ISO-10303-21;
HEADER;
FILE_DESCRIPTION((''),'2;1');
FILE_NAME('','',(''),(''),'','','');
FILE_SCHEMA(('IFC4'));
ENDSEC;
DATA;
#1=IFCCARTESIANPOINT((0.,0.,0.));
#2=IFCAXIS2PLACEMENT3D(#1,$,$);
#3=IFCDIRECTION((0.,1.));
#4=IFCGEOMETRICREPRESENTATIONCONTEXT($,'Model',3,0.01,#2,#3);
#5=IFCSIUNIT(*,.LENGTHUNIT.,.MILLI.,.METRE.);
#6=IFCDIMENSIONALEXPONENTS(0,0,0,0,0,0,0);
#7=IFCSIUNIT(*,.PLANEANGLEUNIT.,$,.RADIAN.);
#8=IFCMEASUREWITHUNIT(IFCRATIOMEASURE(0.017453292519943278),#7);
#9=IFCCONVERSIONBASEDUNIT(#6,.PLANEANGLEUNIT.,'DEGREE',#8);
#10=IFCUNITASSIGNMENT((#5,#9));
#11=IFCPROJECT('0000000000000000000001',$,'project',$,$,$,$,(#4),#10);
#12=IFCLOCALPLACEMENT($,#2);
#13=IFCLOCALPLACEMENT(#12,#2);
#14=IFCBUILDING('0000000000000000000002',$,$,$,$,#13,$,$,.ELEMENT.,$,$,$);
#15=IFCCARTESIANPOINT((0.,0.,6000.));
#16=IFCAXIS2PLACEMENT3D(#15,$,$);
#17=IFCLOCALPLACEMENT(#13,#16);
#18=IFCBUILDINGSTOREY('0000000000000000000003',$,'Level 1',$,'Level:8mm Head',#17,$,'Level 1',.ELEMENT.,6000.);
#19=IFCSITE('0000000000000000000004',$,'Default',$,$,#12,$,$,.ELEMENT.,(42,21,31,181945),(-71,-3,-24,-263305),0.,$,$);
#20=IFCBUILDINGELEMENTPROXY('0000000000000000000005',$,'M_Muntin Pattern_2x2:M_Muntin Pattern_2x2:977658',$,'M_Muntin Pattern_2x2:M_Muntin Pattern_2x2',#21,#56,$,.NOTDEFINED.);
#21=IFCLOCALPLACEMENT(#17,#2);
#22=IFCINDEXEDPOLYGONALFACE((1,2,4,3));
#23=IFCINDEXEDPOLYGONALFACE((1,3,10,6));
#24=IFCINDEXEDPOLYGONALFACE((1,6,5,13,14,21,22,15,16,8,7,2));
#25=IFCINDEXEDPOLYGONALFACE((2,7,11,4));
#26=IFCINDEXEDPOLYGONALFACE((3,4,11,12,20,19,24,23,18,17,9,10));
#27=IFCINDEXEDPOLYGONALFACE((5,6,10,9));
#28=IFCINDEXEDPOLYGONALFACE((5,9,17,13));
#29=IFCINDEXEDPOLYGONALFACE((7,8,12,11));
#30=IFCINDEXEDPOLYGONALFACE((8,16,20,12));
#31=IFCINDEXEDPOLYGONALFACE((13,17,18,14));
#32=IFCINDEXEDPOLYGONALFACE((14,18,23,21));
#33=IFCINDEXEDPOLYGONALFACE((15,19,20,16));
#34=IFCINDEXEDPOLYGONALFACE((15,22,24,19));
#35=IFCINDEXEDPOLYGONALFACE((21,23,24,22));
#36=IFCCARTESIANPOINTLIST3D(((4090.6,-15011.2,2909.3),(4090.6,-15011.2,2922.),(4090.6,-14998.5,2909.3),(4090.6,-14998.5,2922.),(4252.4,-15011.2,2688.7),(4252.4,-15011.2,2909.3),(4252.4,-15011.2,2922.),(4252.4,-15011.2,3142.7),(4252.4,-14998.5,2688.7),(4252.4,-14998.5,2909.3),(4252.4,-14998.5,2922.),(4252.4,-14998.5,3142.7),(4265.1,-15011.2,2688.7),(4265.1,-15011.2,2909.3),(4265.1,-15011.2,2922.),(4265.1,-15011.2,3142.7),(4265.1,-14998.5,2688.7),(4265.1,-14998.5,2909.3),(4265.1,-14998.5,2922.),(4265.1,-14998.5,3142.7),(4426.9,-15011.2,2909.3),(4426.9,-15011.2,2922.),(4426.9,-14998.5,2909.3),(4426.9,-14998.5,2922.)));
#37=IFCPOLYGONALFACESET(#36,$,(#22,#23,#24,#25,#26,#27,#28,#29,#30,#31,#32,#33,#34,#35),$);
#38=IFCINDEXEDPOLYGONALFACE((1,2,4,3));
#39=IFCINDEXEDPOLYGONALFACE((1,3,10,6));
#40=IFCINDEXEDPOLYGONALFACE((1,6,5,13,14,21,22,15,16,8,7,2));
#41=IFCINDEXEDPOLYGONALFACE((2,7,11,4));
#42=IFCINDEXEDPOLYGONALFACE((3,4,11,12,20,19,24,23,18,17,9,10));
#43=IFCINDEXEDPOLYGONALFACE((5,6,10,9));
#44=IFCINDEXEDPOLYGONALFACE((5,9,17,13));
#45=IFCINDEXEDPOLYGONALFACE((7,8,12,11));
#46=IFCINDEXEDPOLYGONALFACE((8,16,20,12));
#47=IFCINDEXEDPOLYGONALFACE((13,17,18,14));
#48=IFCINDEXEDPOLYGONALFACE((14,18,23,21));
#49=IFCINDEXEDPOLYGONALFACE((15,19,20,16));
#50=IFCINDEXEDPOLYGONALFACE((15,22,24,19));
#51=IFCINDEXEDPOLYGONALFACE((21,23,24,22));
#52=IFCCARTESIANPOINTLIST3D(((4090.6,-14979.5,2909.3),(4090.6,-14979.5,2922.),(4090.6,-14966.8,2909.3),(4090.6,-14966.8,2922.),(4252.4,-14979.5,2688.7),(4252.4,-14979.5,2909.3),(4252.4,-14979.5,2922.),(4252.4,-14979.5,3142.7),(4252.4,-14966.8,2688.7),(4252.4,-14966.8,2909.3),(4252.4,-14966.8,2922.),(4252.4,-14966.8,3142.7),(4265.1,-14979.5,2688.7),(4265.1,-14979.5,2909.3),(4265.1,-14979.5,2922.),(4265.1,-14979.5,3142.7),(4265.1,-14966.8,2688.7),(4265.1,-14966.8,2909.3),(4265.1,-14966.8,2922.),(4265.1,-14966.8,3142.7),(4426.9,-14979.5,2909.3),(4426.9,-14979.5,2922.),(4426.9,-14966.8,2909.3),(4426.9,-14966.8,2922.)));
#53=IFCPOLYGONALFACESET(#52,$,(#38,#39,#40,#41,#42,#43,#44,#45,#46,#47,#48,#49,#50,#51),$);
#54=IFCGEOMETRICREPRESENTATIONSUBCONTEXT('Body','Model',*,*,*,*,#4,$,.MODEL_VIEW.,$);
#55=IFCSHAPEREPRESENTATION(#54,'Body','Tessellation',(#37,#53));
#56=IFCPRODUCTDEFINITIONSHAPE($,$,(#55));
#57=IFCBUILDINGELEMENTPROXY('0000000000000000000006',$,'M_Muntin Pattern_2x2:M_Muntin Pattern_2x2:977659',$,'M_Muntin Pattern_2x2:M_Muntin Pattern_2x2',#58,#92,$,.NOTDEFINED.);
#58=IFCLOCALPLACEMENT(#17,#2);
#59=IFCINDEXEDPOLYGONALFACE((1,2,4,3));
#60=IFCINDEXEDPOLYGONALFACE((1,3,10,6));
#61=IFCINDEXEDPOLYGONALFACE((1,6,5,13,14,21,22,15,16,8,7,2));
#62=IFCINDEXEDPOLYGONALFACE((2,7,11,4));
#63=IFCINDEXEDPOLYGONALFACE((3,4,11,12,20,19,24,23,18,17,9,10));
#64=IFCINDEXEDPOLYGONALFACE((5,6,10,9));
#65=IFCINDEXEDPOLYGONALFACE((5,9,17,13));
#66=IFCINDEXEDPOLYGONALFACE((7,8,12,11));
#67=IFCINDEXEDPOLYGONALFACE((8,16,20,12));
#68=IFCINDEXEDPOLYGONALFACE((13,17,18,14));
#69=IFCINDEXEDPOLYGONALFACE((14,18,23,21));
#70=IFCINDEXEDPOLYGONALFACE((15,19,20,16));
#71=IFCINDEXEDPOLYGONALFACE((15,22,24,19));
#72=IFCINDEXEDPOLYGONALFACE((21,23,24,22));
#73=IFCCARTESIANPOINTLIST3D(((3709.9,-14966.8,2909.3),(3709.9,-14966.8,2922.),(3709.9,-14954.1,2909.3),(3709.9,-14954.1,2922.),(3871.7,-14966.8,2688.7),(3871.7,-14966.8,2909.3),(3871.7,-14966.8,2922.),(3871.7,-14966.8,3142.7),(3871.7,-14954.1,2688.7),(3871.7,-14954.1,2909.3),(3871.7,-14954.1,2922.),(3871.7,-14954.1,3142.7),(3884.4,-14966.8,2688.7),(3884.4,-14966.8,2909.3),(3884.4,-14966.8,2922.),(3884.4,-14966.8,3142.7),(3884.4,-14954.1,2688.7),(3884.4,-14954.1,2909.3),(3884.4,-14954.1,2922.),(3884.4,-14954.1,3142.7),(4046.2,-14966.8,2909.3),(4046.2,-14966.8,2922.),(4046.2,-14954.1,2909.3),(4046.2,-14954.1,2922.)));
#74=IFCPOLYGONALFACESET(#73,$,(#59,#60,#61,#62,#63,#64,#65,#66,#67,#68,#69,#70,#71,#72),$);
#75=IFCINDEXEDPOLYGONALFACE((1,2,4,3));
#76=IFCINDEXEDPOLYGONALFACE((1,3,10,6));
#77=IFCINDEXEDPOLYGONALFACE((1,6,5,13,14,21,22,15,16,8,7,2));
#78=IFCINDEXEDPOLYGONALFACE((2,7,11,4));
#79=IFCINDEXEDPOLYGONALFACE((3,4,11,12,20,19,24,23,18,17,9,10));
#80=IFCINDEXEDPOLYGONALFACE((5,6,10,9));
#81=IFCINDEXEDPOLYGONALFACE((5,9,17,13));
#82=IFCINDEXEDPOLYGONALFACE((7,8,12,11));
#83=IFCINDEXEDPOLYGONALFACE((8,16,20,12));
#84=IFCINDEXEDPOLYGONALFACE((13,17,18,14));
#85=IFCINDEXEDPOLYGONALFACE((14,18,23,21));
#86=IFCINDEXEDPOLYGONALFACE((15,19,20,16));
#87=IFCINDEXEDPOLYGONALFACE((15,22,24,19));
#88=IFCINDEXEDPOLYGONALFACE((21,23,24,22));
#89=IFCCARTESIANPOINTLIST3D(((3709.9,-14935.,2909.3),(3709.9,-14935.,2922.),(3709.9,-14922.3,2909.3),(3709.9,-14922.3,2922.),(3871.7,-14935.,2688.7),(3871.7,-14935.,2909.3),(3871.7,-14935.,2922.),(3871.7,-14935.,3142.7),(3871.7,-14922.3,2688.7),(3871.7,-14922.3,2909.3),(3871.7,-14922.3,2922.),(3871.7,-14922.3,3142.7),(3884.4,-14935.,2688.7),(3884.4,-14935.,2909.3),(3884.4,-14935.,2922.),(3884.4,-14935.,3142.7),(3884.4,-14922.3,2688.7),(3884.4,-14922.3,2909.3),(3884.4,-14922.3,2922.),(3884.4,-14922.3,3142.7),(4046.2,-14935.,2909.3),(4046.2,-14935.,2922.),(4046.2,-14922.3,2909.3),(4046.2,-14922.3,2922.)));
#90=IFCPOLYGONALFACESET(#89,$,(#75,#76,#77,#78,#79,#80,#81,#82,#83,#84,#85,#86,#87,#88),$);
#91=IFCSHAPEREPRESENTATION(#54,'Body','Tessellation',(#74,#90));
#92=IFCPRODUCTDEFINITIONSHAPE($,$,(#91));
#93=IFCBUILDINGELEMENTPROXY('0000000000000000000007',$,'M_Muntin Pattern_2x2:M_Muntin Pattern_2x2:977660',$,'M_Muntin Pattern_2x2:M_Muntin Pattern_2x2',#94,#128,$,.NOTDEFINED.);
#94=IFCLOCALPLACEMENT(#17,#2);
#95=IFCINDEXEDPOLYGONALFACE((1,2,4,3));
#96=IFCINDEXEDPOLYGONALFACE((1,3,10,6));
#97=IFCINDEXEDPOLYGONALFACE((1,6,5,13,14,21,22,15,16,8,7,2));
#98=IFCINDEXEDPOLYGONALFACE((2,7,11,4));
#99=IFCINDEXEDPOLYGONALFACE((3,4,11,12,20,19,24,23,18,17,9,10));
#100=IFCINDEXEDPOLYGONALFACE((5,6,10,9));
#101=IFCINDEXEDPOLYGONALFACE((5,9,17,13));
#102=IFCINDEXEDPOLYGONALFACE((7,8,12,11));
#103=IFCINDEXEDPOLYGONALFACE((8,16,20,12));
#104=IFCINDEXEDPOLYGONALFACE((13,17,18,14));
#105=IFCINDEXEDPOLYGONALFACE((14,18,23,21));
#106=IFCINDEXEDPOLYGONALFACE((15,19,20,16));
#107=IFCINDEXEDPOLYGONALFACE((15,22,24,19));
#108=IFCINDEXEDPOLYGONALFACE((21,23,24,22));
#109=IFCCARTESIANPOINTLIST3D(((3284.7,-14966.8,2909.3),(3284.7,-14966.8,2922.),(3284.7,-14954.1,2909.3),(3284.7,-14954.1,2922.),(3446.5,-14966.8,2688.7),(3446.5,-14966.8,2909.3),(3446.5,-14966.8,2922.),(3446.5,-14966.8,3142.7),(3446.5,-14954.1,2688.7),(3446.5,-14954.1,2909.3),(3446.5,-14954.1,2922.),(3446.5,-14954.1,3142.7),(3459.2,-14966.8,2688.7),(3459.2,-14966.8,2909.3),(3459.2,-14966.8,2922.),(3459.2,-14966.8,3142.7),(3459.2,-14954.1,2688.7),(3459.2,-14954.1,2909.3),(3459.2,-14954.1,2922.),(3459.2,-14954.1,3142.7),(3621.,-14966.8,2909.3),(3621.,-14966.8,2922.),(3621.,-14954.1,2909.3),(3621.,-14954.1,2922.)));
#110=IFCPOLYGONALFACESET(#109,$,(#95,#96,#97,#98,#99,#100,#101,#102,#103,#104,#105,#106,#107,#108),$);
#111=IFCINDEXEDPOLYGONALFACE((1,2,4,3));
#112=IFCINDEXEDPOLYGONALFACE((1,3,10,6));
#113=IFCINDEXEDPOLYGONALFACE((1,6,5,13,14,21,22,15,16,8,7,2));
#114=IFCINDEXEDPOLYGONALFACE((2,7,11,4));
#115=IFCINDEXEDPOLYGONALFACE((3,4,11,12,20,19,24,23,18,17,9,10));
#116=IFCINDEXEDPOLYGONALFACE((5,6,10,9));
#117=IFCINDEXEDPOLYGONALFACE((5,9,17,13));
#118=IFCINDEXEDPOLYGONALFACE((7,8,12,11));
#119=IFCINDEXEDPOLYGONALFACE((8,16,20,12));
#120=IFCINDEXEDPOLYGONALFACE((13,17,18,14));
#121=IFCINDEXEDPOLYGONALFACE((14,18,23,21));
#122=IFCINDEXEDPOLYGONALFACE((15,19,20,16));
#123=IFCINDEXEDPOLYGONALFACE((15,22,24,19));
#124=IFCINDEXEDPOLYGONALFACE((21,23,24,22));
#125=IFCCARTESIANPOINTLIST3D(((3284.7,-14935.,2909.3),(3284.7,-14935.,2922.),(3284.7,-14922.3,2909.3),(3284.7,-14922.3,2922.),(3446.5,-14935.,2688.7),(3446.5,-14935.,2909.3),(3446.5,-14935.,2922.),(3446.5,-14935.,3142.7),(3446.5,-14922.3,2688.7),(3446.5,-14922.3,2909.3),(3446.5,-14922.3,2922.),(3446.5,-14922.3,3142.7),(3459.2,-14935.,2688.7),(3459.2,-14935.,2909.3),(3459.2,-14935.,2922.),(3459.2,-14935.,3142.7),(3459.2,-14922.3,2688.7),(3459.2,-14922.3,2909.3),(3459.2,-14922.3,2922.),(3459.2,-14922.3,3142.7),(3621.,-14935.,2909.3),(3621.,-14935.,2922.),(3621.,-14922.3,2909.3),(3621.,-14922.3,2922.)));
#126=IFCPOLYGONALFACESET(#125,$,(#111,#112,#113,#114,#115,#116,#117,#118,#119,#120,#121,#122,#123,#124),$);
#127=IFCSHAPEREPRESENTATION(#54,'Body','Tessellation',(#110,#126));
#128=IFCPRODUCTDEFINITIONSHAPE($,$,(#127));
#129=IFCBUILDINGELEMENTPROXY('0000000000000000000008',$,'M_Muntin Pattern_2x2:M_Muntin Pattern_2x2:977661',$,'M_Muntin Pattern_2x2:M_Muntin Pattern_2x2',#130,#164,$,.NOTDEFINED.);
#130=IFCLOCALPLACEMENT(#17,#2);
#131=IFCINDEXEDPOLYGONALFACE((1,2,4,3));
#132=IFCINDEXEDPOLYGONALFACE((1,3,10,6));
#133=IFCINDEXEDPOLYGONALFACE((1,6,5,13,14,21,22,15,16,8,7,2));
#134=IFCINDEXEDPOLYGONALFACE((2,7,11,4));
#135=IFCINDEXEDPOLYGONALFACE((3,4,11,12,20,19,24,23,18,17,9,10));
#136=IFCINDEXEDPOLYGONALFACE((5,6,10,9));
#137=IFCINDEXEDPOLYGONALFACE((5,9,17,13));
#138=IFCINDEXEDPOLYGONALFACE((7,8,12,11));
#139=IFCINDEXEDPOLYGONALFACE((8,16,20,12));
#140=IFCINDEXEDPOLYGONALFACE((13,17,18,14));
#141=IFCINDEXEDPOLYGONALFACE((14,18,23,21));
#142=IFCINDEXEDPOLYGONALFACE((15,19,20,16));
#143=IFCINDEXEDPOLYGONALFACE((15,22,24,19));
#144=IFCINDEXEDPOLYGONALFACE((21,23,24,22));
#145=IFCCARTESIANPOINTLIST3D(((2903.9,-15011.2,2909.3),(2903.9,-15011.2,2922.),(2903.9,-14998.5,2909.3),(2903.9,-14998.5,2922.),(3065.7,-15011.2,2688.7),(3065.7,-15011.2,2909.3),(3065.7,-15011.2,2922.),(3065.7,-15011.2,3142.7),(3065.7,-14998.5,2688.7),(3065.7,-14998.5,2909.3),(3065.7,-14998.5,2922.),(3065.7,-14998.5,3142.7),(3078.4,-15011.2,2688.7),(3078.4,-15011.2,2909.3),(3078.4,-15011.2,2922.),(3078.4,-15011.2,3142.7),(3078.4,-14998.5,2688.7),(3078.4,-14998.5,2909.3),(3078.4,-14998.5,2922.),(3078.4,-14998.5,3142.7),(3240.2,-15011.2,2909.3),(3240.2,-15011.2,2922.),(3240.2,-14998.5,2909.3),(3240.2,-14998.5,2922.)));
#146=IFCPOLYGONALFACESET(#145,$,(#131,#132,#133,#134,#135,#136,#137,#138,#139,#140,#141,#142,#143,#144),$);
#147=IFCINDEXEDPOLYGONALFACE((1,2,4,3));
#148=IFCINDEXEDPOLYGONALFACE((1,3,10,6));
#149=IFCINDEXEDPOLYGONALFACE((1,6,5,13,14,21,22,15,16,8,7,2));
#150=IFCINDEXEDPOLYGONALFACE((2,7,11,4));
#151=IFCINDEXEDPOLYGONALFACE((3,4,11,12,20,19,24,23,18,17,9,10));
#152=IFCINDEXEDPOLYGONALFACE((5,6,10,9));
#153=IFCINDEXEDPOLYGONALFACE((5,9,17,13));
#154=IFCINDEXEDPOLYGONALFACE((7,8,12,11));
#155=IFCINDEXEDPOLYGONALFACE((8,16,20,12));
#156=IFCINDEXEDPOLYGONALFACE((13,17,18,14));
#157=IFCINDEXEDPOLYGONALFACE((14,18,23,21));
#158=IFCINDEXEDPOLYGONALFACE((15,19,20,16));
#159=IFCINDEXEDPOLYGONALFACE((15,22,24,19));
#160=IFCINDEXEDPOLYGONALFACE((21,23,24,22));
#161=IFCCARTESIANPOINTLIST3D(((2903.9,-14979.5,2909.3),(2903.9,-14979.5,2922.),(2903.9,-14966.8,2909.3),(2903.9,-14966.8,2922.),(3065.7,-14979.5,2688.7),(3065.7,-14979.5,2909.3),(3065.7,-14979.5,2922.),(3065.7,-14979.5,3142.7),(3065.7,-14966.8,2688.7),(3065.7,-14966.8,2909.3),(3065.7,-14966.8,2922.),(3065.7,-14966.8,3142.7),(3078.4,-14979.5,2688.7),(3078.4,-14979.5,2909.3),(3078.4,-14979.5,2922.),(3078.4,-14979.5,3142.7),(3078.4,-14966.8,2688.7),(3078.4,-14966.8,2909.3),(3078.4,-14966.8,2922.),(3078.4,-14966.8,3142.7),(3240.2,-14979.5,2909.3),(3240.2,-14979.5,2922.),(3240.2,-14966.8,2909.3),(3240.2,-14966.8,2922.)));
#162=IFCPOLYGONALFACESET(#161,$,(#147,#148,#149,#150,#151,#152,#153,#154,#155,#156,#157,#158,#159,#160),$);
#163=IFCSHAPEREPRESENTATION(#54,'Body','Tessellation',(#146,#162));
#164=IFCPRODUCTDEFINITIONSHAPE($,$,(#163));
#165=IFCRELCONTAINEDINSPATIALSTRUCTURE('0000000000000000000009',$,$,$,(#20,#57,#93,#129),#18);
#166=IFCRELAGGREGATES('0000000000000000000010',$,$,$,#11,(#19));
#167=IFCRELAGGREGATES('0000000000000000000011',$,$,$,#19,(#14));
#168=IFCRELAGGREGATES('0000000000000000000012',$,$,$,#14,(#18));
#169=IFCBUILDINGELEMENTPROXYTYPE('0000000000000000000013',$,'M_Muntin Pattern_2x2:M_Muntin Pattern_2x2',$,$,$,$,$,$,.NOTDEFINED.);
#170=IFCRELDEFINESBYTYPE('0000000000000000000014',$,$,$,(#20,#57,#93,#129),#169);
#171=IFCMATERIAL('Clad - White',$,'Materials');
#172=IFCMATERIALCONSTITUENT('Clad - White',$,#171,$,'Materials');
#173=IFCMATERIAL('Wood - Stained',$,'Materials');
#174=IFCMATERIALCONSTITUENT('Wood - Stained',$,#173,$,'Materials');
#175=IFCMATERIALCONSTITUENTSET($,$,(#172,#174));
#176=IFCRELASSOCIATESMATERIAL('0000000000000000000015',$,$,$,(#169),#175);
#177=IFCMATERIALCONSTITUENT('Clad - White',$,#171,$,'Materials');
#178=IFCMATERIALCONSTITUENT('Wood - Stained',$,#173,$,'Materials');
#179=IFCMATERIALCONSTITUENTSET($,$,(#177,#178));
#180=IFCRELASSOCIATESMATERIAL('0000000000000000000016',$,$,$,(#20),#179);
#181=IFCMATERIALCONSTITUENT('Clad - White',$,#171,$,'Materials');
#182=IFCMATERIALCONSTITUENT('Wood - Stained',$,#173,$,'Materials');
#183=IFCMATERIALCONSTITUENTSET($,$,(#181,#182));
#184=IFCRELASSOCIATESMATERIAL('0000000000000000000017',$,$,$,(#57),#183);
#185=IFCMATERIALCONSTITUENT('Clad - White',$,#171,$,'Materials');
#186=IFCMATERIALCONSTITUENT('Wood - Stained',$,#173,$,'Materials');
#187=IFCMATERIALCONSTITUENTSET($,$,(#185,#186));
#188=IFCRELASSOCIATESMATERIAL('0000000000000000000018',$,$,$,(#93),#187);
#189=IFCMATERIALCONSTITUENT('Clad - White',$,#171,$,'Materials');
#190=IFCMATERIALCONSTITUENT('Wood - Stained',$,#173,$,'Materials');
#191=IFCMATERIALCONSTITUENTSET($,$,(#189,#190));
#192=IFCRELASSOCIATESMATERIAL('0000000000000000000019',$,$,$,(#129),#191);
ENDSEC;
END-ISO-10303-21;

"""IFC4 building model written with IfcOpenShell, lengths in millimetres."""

from ifc_helpers import new_model, entity, si_unit, converted_unit, direction, frame, origin, place, context, subcontext, project, spatial, indexed_curve, outline, extrude, source, transform, mapped, material, constituent, constituent_set, type_object, type_shapes, element, save


model = new_model("IFC4")

# Units and contexts
model_context = context("Model", 3, precision=0.01, world=origin(), true_north=direction((0.0, 1.0)))
body_context = subcontext(model_context, "Body", "Model", "MODEL_VIEW")
ifc_project = project(units=[si_unit("LENGTHUNIT", "METRE", prefix="MILLI"), converted_unit("PLANEANGLEUNIT", "DEGREE", entity("IfcRatioMeasure", 0.017453292519943278), si_unit("PLANEANGLEUNIT", "RADIAN"), dimensions=[0, 0, 0, 0, 0, 0, 0])], contexts=[model_context])

# Site, building, storey
site_placement = place(None, origin())
site = spatial("IfcSite", under=ifc_project, at=site_placement, Name="Default", CompositionType="ELEMENT", RefLatitude=(42, 21, 31, 181945), RefLongitude=(-71, -3, -24, -263305), RefElevation=0.0)
building_placement = place(site_placement, origin())
building = spatial("IfcBuilding", under=site, at=building_placement, CompositionType="ELEMENT")
storey_placement = place(building_placement, frame((0.0, 0.0, 6000.0)))
storey = spatial("IfcBuildingStorey", under=building, at=storey_placement, Name="Level 1", ObjectType="Level:8mm Head", LongName="Level 1", CompositionType="ELEMENT", Elevation=6000.0)

# Building element proxies
ifc_material_1 = material(Name="Clad - White", Category="Materials")
ifc_material_2 = material(Name="Wood - Stained", Category="Materials")
ifc_constituent_1 = constituent(ifc_material_1, Name="Clad - White", Category="Materials")
ifc_constituent_2 = constituent(ifc_material_2, Name="Wood - Stained", Category="Materials")
ifc_constituent_set_1 = constituent_set(constituents=[ifc_constituent_1, ifc_constituent_2])
building_element_proxy_type_1 = type_object("IfcBuildingElementProxyType", Name="M_Muntin Pattern_2x2:M_Muntin Pattern_2x2", PredefinedType="NOTDEFINED", material=ifc_constituent_set_1)
shared_shape_1 = source(origin(), body_context, "Body", "SweptSolid", [
    extrude(outline(indexed_curve([(6.4, -6.4), (227.0, -6.4), (227.0, 6.3), (6.4, 6.3), (6.4, 168.2), (-6.3, 168.2), (-6.3, 6.3), (-227.0, 6.3), (-227.0, -6.4), (-6.3, -6.4), (-6.3, -168.1), (6.4, -168.1), (6.4, -6.4)], self_intersect=False)), frame((0.0, 9.5, 227.0), z_axis=(0.0, 1.0, 0.0), x_axis=(0.0, 0.0, 1.0)), (0.0, 0.0, 1.0), 12.7),
    extrude(outline(indexed_curve([(6.4, -6.4), (227.0, -6.4), (227.0, 6.3), (6.4, 6.3), (6.4, 168.2), (-6.3, 168.2), (-6.3, 6.3), (-227.0, 6.3), (-227.0, -6.4), (-6.3, -6.4), (-6.3, -168.1), (6.4, -168.1), (6.4, -6.4)], self_intersect=False)), frame((0.0, -22.2, 227.0), z_axis=(0.0, 1.0, 0.0), x_axis=(0.0, 0.0, 1.0)), (0.0, 0.0, 1.0), 12.7),
])
type_shapes(building_element_proxy_type_1, [shared_shape_1])
ifc_constituent_3 = constituent(ifc_material_1, Name="Clad - White", Category="Materials")
ifc_constituent_4 = constituent(ifc_material_2, Name="Wood - Stained", Category="Materials")
ifc_constituent_set_2 = constituent_set(constituents=[ifc_constituent_3, ifc_constituent_4])
proxy_1_placement = place(storey_placement, frame((4258.8, -14989.0, 2688.7), z_axis=(0.0, 0.0, 1.0), x_axis=(-1.0, 0.0, 0.0)))
element("IfcBuildingElementProxy", 1, at=proxy_1_placement, inside=storey, type_object=building_element_proxy_type_1, material=ifc_constituent_set_2, Name="M_Muntin Pattern_2x2:M_Muntin Pattern_2x2:977658", ObjectType="M_Muntin Pattern_2x2:M_Muntin Pattern_2x2", PredefinedType="NOTDEFINED", context=body_context, shape_type="MappedRepresentation", body=[
    mapped(shared_shape_1, transform((0.0, 0.0, 0.0), scale=1.0)),
])
ifc_constituent_5 = constituent(ifc_material_1, Name="Clad - White", Category="Materials")
ifc_constituent_6 = constituent(ifc_material_2, Name="Wood - Stained", Category="Materials")
ifc_constituent_set_3 = constituent_set(constituents=[ifc_constituent_5, ifc_constituent_6])
proxy_2_placement = place(storey_placement, frame((3878.0, -14944.6, 2688.7), z_axis=(0.0, 0.0, 1.0), x_axis=(-1.0, 0.0, 0.0)))
element("IfcBuildingElementProxy", 2, at=proxy_2_placement, inside=storey, type_object=building_element_proxy_type_1, material=ifc_constituent_set_3, Name="M_Muntin Pattern_2x2:M_Muntin Pattern_2x2:977659", ObjectType="M_Muntin Pattern_2x2:M_Muntin Pattern_2x2", PredefinedType="NOTDEFINED", context=body_context, shape_type="MappedRepresentation", body=[
    mapped(shared_shape_1, transform((0.0, 0.0, 0.0), scale=1.0)),
])
ifc_constituent_7 = constituent(ifc_material_1, Name="Clad - White", Category="Materials")
ifc_constituent_8 = constituent(ifc_material_2, Name="Wood - Stained", Category="Materials")
ifc_constituent_set_4 = constituent_set(constituents=[ifc_constituent_7, ifc_constituent_8])
proxy_3_placement = place(storey_placement, frame((3452.8, -14944.6, 2688.7), z_axis=(0.0, 0.0, 1.0), x_axis=(-1.0, 0.0, 0.0)))
element("IfcBuildingElementProxy", 3, at=proxy_3_placement, inside=storey, type_object=building_element_proxy_type_1, material=ifc_constituent_set_4, Name="M_Muntin Pattern_2x2:M_Muntin Pattern_2x2:977660", ObjectType="M_Muntin Pattern_2x2:M_Muntin Pattern_2x2", PredefinedType="NOTDEFINED", context=body_context, shape_type="MappedRepresentation", body=[
    mapped(shared_shape_1, transform((0.0, 0.0, 0.0), scale=1.0)),
])
ifc_constituent_9 = constituent(ifc_material_1, Name="Clad - White", Category="Materials")
ifc_constituent_10 = constituent(ifc_material_2, Name="Wood - Stained", Category="Materials")
ifc_constituent_set_5 = constituent_set(constituents=[ifc_constituent_9, ifc_constituent_10])
proxy_4_placement = place(storey_placement, frame((3072.1, -14989.0, 2688.7), z_axis=(0.0, 0.0, 1.0), x_axis=(-1.0, 0.0, 0.0)))
element("IfcBuildingElementProxy", 4, at=proxy_4_placement, inside=storey, type_object=building_element_proxy_type_1, material=ifc_constituent_set_5, Name="M_Muntin Pattern_2x2:M_Muntin Pattern_2x2:977661", ObjectType="M_Muntin Pattern_2x2:M_Muntin Pattern_2x2", PredefinedType="NOTDEFINED", context=body_context, shape_type="MappedRepresentation", body=[
    mapped(shared_shape_1, transform((0.0, 0.0, 0.0), scale=1.0)),
])

save(model, "model.ifc")
